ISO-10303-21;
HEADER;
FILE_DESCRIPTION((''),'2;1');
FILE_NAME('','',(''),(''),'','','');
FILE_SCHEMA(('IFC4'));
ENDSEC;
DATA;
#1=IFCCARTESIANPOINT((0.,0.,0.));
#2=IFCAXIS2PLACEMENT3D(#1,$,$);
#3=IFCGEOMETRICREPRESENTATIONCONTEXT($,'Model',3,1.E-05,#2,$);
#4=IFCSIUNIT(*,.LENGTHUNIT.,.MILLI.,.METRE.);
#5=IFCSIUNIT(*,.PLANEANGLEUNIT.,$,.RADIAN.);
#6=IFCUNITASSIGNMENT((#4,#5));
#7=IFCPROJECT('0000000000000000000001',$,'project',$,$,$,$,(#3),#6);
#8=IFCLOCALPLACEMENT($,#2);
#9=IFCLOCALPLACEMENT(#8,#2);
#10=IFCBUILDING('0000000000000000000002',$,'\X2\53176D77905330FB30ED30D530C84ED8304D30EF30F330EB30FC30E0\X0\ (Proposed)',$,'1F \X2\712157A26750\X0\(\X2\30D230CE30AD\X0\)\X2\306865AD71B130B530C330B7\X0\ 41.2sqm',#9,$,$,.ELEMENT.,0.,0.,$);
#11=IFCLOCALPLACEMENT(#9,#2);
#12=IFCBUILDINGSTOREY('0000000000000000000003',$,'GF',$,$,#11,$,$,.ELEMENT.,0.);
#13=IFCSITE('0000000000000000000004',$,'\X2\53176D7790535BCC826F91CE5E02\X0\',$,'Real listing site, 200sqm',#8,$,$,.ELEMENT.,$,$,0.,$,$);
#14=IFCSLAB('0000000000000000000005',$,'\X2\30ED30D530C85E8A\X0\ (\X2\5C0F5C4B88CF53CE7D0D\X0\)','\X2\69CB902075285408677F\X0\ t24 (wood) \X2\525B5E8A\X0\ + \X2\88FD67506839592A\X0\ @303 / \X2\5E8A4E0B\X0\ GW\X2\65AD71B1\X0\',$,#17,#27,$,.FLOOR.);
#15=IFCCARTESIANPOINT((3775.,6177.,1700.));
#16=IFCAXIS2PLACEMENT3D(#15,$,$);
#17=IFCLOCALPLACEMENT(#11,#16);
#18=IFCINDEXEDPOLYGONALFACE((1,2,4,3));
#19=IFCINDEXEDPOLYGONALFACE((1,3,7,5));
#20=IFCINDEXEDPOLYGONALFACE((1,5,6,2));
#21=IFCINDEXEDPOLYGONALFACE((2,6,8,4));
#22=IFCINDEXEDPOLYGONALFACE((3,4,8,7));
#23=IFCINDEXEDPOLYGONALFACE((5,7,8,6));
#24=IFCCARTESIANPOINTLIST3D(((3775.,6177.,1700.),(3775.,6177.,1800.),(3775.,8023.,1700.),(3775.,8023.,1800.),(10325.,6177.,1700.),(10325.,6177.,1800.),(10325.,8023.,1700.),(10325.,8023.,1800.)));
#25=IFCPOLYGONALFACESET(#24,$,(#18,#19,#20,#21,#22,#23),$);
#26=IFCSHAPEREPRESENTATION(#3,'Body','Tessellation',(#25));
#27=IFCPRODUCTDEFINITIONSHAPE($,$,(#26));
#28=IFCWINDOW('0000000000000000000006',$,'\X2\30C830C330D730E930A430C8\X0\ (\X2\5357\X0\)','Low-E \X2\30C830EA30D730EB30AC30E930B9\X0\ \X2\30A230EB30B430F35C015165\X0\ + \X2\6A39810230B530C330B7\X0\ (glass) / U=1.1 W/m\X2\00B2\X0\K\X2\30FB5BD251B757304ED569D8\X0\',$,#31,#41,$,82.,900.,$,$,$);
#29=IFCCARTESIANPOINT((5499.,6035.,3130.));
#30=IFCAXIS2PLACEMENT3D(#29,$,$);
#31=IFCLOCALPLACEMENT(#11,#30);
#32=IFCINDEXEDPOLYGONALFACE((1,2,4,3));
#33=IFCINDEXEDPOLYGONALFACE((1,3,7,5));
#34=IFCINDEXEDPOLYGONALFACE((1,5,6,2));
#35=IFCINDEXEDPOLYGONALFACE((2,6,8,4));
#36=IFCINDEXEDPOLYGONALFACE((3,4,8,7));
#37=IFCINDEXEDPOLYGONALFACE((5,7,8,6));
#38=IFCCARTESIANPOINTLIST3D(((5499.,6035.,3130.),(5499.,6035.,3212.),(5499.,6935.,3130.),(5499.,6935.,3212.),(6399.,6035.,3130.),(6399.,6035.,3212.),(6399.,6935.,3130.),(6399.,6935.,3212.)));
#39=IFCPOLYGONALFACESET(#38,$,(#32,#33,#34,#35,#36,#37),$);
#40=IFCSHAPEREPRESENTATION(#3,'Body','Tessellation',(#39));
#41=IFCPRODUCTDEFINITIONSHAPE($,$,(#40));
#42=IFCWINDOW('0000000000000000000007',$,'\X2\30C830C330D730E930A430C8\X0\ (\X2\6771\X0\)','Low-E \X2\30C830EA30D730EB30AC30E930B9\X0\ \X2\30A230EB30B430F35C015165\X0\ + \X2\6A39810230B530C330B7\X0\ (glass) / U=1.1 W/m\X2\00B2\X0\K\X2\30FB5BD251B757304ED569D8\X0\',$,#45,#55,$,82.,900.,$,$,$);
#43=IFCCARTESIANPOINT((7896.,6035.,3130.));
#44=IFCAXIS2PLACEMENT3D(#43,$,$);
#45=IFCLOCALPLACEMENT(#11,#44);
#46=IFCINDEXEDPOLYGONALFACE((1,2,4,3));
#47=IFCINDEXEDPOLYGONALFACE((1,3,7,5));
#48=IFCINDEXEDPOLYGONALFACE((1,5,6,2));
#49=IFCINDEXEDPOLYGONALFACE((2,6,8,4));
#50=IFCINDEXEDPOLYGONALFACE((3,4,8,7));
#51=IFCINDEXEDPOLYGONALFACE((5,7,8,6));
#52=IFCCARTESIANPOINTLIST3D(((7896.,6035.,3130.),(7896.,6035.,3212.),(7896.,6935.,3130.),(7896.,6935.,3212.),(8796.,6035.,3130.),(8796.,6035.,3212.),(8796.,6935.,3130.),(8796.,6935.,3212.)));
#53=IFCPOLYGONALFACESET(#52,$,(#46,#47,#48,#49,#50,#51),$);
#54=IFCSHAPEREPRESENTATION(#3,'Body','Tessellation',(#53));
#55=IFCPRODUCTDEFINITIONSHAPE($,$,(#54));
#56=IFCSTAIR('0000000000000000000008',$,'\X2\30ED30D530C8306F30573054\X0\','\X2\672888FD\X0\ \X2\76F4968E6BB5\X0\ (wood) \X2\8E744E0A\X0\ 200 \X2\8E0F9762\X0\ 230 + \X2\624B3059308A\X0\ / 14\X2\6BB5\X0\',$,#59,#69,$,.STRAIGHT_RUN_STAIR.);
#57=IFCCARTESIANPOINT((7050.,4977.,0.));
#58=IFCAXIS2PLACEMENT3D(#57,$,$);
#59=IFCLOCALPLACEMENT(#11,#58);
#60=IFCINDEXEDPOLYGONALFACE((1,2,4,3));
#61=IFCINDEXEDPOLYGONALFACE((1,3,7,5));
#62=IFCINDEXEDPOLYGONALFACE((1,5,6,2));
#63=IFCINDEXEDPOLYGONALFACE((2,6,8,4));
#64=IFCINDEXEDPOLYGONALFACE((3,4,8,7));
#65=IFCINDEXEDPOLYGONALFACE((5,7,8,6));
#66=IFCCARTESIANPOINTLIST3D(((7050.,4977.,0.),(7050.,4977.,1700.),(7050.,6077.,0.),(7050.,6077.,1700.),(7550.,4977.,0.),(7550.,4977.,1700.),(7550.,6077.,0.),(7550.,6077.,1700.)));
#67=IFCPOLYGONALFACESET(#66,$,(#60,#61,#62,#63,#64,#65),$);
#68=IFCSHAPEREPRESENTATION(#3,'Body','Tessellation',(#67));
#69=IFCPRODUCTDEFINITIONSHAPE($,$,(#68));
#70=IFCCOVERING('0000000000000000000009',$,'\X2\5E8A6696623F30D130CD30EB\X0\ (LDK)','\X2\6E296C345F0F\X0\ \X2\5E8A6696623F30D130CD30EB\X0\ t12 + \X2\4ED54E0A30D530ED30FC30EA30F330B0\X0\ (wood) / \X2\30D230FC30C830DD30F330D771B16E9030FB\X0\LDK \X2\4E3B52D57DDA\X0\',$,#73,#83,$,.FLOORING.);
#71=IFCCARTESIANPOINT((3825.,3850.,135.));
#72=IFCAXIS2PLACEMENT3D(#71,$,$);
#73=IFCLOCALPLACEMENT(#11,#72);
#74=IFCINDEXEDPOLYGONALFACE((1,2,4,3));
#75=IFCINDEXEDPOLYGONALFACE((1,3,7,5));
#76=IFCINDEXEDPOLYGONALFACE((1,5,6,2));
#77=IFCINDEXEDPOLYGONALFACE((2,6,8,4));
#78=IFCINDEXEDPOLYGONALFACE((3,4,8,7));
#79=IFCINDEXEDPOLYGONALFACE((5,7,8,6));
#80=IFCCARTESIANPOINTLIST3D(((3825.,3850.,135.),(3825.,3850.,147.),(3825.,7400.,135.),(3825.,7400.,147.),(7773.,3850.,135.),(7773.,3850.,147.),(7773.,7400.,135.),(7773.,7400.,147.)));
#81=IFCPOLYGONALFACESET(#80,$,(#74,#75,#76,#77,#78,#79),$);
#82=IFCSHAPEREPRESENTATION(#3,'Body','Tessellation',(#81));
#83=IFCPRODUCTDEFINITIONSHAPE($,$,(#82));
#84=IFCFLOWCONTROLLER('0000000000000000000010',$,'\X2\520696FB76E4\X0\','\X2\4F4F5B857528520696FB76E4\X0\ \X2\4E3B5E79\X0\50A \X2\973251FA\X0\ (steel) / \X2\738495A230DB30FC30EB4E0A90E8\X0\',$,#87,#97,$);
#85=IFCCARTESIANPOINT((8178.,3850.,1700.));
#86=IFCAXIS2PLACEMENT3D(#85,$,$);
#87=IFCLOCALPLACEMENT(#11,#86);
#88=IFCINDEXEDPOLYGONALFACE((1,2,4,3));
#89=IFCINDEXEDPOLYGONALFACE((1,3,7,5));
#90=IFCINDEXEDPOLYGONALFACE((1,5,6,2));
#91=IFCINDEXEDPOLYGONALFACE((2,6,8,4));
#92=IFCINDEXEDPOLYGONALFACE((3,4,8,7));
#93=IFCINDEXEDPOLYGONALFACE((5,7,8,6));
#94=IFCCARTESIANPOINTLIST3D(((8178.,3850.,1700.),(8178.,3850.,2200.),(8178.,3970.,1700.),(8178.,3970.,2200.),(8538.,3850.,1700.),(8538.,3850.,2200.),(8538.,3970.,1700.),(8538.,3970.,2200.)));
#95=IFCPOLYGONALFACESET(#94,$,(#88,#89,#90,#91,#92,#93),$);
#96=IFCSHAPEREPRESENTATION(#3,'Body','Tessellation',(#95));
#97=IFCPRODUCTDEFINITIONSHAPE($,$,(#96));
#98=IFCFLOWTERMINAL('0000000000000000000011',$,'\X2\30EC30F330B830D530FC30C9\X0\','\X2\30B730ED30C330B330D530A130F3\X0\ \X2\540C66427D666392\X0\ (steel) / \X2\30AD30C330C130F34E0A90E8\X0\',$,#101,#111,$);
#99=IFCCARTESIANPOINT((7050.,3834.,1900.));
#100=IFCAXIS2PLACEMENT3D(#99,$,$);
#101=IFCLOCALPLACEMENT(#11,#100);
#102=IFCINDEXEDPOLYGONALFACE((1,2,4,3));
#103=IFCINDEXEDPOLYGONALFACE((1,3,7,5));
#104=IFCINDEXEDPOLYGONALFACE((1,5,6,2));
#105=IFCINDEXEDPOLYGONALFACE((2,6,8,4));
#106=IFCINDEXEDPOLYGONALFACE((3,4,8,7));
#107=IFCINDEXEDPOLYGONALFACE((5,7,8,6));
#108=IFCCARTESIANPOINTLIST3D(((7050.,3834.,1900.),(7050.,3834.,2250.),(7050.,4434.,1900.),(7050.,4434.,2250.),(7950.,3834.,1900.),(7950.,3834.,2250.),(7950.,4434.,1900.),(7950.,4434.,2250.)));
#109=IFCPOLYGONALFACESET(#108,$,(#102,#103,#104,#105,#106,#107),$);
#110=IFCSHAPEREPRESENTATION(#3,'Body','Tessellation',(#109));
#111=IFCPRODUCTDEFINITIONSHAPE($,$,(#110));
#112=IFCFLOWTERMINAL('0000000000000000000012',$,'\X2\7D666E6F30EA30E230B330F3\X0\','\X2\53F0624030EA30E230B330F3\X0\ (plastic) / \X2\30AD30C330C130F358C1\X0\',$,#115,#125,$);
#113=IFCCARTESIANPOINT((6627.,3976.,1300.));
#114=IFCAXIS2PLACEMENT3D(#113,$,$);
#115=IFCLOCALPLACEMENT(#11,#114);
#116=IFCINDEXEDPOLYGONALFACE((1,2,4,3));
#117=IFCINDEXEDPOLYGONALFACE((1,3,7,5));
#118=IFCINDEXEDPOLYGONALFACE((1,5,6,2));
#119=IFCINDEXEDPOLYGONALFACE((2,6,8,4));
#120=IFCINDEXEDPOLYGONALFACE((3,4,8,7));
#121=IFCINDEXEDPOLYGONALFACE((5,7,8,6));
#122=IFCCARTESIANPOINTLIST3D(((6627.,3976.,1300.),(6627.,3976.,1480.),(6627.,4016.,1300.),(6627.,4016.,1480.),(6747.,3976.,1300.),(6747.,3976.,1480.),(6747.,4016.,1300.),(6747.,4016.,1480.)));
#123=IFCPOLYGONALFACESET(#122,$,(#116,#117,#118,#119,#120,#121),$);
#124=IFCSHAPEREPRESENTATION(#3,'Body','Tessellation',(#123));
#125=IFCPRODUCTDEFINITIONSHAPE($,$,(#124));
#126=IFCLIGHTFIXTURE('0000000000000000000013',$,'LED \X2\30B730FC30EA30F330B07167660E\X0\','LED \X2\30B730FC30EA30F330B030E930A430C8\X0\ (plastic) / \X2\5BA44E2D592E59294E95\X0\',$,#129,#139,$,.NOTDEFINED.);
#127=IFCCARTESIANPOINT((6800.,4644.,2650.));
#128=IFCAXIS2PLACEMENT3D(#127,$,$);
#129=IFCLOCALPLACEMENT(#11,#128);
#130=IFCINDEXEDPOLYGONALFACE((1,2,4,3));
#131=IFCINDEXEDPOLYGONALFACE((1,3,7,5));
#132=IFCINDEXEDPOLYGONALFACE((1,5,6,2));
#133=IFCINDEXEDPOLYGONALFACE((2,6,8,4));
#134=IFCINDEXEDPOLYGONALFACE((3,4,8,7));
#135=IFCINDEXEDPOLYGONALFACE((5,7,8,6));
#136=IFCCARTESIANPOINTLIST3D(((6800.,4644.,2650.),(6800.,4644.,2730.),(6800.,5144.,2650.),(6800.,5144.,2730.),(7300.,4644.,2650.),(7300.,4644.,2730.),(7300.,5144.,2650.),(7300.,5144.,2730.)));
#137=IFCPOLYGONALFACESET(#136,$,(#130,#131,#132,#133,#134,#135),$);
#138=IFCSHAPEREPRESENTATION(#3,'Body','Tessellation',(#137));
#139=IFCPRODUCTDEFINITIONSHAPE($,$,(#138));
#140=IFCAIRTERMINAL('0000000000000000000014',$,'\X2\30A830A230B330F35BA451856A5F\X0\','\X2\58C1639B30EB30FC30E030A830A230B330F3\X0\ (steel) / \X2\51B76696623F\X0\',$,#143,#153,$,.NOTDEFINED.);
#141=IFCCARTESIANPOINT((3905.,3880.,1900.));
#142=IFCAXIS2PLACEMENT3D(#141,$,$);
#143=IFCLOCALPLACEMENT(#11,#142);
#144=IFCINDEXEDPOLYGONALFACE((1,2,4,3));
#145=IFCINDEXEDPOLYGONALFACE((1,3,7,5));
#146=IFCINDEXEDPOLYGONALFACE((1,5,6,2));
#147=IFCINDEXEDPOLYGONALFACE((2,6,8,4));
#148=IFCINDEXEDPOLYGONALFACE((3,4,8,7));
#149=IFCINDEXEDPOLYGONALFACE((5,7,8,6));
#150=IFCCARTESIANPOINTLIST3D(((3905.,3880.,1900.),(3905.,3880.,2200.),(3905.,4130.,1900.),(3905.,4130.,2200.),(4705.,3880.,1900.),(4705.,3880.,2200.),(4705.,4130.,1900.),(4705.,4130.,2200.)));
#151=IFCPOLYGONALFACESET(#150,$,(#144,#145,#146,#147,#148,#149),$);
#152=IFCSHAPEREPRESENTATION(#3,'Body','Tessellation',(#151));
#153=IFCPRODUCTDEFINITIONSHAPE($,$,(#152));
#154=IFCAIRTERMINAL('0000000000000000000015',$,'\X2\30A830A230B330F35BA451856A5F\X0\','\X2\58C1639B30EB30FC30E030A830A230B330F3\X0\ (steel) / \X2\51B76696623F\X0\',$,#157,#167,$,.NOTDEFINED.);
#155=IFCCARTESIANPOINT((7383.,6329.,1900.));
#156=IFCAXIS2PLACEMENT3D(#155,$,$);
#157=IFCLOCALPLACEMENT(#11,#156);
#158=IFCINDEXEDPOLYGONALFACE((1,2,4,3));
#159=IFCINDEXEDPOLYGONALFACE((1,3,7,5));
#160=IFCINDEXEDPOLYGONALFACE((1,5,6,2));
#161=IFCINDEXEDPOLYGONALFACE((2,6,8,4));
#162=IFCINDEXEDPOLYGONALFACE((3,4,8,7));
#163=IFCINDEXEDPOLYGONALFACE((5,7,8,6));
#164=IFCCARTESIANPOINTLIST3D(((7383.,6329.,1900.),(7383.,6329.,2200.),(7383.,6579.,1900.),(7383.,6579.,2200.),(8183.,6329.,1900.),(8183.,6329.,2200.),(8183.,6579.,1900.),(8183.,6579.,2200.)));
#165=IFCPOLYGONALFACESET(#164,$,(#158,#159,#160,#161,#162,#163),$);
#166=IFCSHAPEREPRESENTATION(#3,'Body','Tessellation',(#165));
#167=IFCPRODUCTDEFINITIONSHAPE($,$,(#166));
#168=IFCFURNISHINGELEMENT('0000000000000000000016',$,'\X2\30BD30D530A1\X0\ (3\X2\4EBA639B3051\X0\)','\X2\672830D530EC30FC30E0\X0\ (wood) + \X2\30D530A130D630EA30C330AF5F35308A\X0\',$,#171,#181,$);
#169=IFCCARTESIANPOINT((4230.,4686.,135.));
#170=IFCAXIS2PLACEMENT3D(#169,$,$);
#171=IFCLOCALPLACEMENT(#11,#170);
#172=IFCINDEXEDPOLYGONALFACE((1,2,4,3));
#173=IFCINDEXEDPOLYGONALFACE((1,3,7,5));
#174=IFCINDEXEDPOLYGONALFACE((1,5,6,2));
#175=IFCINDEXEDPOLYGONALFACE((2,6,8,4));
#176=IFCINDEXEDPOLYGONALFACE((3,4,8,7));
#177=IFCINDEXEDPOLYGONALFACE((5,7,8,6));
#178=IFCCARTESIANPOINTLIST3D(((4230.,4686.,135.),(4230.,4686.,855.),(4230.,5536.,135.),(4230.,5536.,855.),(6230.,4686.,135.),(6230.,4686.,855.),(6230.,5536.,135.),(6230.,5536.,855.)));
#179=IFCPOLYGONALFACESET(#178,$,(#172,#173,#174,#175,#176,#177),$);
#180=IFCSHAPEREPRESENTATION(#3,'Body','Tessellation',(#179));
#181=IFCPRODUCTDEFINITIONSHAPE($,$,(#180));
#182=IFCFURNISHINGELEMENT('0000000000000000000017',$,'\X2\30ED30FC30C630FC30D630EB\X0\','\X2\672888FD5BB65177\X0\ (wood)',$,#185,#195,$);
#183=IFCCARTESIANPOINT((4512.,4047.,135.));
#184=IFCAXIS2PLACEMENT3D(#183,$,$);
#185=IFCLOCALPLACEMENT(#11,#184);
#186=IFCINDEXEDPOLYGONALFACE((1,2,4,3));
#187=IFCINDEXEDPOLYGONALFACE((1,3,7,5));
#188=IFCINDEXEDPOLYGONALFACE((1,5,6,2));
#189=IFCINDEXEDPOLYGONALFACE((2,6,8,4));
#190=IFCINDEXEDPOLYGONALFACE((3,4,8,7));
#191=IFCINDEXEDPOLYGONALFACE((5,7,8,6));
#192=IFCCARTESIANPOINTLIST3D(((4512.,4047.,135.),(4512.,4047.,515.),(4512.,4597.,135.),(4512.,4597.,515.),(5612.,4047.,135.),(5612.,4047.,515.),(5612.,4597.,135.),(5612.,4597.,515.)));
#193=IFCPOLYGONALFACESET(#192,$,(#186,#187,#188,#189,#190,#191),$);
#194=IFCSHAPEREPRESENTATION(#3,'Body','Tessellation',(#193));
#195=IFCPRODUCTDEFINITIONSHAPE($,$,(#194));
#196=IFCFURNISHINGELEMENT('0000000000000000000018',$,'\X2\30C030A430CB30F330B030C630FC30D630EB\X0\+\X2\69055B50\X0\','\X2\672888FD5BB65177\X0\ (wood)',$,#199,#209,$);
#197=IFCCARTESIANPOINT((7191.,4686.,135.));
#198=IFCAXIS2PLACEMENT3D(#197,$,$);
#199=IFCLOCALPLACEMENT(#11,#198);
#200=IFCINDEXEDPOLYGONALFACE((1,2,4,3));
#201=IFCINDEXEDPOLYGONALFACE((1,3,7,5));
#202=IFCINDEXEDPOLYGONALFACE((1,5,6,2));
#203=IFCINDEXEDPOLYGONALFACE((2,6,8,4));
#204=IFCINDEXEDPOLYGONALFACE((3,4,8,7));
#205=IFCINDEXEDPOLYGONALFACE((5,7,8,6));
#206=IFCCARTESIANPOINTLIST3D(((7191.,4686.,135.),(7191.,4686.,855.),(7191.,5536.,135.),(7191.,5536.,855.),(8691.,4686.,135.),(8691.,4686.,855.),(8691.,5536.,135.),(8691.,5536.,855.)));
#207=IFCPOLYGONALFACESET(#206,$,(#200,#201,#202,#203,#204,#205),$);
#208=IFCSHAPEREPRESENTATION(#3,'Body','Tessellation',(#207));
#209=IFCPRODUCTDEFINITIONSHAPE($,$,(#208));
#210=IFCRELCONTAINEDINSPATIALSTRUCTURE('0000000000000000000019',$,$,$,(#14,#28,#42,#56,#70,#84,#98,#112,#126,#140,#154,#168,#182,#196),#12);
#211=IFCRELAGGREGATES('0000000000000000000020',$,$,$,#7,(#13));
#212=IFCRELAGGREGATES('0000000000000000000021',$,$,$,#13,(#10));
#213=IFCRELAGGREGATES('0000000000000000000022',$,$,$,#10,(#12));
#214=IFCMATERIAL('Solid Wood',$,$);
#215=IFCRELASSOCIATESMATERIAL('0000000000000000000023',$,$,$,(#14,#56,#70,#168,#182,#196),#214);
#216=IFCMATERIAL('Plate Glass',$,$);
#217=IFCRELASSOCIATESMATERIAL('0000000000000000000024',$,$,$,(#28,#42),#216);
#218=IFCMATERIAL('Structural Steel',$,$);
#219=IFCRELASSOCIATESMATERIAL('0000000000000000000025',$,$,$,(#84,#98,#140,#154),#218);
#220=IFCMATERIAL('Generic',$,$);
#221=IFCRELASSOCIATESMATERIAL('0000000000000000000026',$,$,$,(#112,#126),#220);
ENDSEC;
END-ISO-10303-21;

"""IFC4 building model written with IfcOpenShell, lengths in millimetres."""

from ifc_helpers import new_model, si_unit, frame, frame_2d, origin, place, context, project, spatial, rectangle, extrude, material, element, save


model = new_model("IFC4")

# Units and contexts
model_context = context("Model", 3, precision=1e-05, world=origin())
ifc_project = project(units=[si_unit("LENGTHUNIT", "METRE", prefix="MILLI"), si_unit("PLANEANGLEUNIT", "RADIAN")], contexts=[model_context])

# Site, building, storey
site_placement = place(None, origin())
site = spatial("IfcSite", under=ifc_project, at=site_placement, Name="北海道富良野市", ObjectType="Real listing site, 200sqm", CompositionType="ELEMENT", RefElevation=0.0)
building_placement = place(site_placement, origin())
building = spatial("IfcBuilding", under=site, at=building_placement, Name="北海道・ロフト付きワンルーム (Proposed)", ObjectType="1F 無垢材(ヒノキ)と断熱サッシ 41.2sqm", CompositionType="ELEMENT", ElevationOfRefHeight=0.0, ElevationOfTerrain=0.0)
storey_placement = place(building_placement, origin())
storey = spatial("IfcBuildingStorey", under=building, at=storey_placement, Name="GF", CompositionType="ELEMENT", Elevation=0.0)

# Shared definitions
ifc_material_1 = material(Name="Solid Wood")

# Slab
slab_placement = place(storey_placement, frame((3775.0, 6177.0, 1700.0)))
element("IfcSlab", 1, at=slab_placement, inside=storey, material=ifc_material_1, Name="ロフト床 (小屋裏収納)", Description="構造用合板 t24 (wood) 剛床 + 製材根太 @303 / 床下 GW断熱", PredefinedType="FLOOR", context=model_context, shape_type="SweptSolid", body=[
    extrude(rectangle(XDim=6550.0, YDim=1846.0, at=frame_2d((3275.0, 923.0))), frame((3775.0, 6177.0, 1700.0)), (0.0, 0.0, 1.0), 100.0),
])

# Windows
ifc_material_2 = material(Name="Plate Glass")
window_1_placement = place(storey_placement, frame((5499.0, 6035.0, 3130.0)))
element("IfcWindow", 2, at=window_1_placement, inside=storey, material=ifc_material_2, Name="トップライト (南)", Description="Low-E トリプルガラス アルゴン封入 + 樹脂サッシ (glass) / U=1.1 W/m²K・寒冷地仕様", OverallHeight=82.0, OverallWidth=900.0, context=model_context, shape_type="SweptSolid", body=[
    extrude(rectangle(XDim=900.0, YDim=900.0, at=frame_2d((450.0, 450.0))), frame((5499.0, 6035.0, 3130.0)), (0.0, 0.0, 1.0), 82.0),
])
window_2_placement = place(storey_placement, frame((7896.0, 6035.0, 3130.0)))
element("IfcWindow", 3, at=window_2_placement, inside=storey, material=ifc_material_2, Name="トップライト (東)", Description="Low-E トリプルガラス アルゴン封入 + 樹脂サッシ (glass) / U=1.1 W/m²K・寒冷地仕様", OverallHeight=82.0, OverallWidth=900.0, context=model_context, shape_type="SweptSolid", body=[
    extrude(rectangle(XDim=900.0, YDim=900.0, at=frame_2d((450.0, 450.0))), frame((7896.0, 6035.0, 3130.0)), (0.0, 0.0, 1.0), 82.0),
])

# Stair
stair_placement = place(storey_placement, frame((7050.0, 4977.0, 0.0)))
element("IfcStair", 4, at=stair_placement, inside=storey, material=ifc_material_1, Name="ロフトはしご", Description="木製 直階段 (wood) 蹴上 200 踏面 230 + 手すり / 14段", PredefinedType="STRAIGHT_RUN_STAIR", context=model_context, shape_type="SweptSolid", body=[
    extrude(rectangle(XDim=500.0, YDim=1100.0, at=frame_2d((250.0, 550.0))), frame((7050.0, 4977.0, 0.0)), (0.0, 0.0, 1.0), 1700.0),
])

# Covering
covering_placement = place(storey_placement, frame((3825.0, 3850.0, 135.0)))
element("IfcCovering", 5, at=covering_placement, inside=storey, material=ifc_material_1, Name="床暖房パネル (LDK)", Description="温水式 床暖房パネル t12 + 仕上フローリング (wood) / ヒートポンプ熱源・LDK 主動線", PredefinedType="FLOORING", context=model_context, shape_type="SweptSolid", body=[
    extrude(rectangle(XDim=3948.0, YDim=3550.0, at=frame_2d((1974.0, 1775.0))), frame((3825.0, 3850.0, 135.0)), (0.0, 0.0, 1.0), 12.0),
])

# Flow controller
ifc_material_3 = material(Name="Structural Steel")
flow_controller_placement = place(storey_placement, frame((8178.0, 3850.0, 1700.0)))
element("IfcFlowController", 6, at=flow_controller_placement, inside=storey, material=ifc_material_3, Name="分電盤", Description="住宅用分電盤 主幹50A 露出 (steel) / 玄関ホール上部", context=model_context, shape_type="SweptSolid", body=[
    extrude(rectangle(XDim=360.0, YDim=120.0, at=frame_2d((180.0, 60.0))), frame((8178.0, 3850.0, 1700.0)), (0.0, 0.0, 1.0), 500.0),
])

# Flow terminals
flow_terminal_1_placement = place(storey_placement, frame((7050.0, 3834.0, 1900.0)))
element("IfcFlowTerminal", 7, at=flow_terminal_1_placement, inside=storey, material=ifc_material_3, Name="レンジフード", Description="シロッコファン 同時給排 (steel) / キッチン上部", context=model_context, shape_type="SweptSolid", body=[
    extrude(rectangle(XDim=900.0, YDim=600.0, at=frame_2d((450.0, 300.0))), frame((7050.0, 3834.0, 1900.0)), (0.0, 0.0, 1.0), 350.0),
])
ifc_material_4 = material(Name="Generic")
flow_terminal_2_placement = place(storey_placement, frame((6627.0, 3976.0, 1300.0)))
element("IfcFlowTerminal", 8, at=flow_terminal_2_placement, inside=storey, material=ifc_material_4, Name="給湯リモコン", Description="台所リモコン (plastic) / キッチン壁", context=model_context, shape_type="SweptSolid", body=[
    extrude(rectangle(XDim=120.0, YDim=40.0, at=frame_2d((60.0, 20.0))), frame((6627.0, 3976.0, 1300.0)), (0.0, 0.0, 1.0), 180.0),
])

# Light fixture
light_fixture_placement = place(storey_placement, frame((6800.0, 4644.0, 2650.0)))
element("IfcLightFixture", 9, at=light_fixture_placement, inside=storey, material=ifc_material_4, Name="LED シーリング照明", Description="LED シーリングライト (plastic) / 室中央天井", PredefinedType="NOTDEFINED", context=model_context, shape_type="SweptSolid", body=[
    extrude(rectangle(XDim=500.0, YDim=500.0, at=frame_2d((250.0, 250.0))), frame((6800.0, 4644.0, 2650.0)), (0.0, 0.0, 1.0), 80.0),
])

# Air terminals
air_terminal_1_placement = place(storey_placement, frame((3905.0, 3880.0, 1900.0)))
element("IfcAirTerminal", 10, at=air_terminal_1_placement, inside=storey, material=ifc_material_3, Name="エアコン室内機", Description="壁掛ルームエアコン (steel) / 冷暖房", PredefinedType="NOTDEFINED", context=model_context, shape_type="SweptSolid", body=[
    extrude(rectangle(XDim=800.0, YDim=250.0, at=frame_2d((400.0, 125.0))), frame((3905.0, 3880.0, 1900.0)), (0.0, 0.0, 1.0), 300.0),
])
air_terminal_2_placement = place(storey_placement, frame((7383.0, 6329.0, 1900.0)))
element("IfcAirTerminal", 11, at=air_terminal_2_placement, inside=storey, material=ifc_material_3, Name="エアコン室内機", Description="壁掛ルームエアコン (steel) / 冷暖房", PredefinedType="NOTDEFINED", context=model_context, shape_type="SweptSolid", body=[
    extrude(rectangle(XDim=800.0, YDim=250.0, at=frame_2d((400.0, 125.0))), frame((7383.0, 6329.0, 1900.0)), (0.0, 0.0, 1.0), 300.0),
])

# Furnishing elements
furnishing_1_placement = place(storey_placement, frame((4230.0, 4686.0, 135.0)))
element("IfcFurnishingElement", 12, at=furnishing_1_placement, inside=storey, material=ifc_material_1, Name="ソファ (3人掛け)", Description="木フレーム (wood) + ファブリック張り", context=model_context, shape_type="SweptSolid", body=[
    extrude(rectangle(XDim=2000.0, YDim=850.0, at=frame_2d((1000.0, 425.0))), frame((4230.0, 4686.0, 135.0)), (0.0, 0.0, 1.0), 720.0),
])
furnishing_2_placement = place(storey_placement, frame((4512.0, 4047.0, 135.0)))
element("IfcFurnishingElement", 13, at=furnishing_2_placement, inside=storey, material=ifc_material_1, Name="ローテーブル", Description="木製家具 (wood)", context=model_context, shape_type="SweptSolid", body=[
    extrude(rectangle(XDim=1100.0, YDim=550.0, at=frame_2d((550.0, 275.0))), frame((4512.0, 4047.0, 135.0)), (0.0, 0.0, 1.0), 380.0),
])
furnishing_3_placement = place(storey_placement, frame((7191.0, 4686.0, 135.0)))
element("IfcFurnishingElement", 14, at=furnishing_3_placement, inside=storey, material=ifc_material_1, Name="ダイニングテーブル+椅子", Description="木製家具 (wood)", context=model_context, shape_type="SweptSolid", body=[
    extrude(rectangle(XDim=1500.0, YDim=850.0, at=frame_2d((750.0, 425.0))), frame((7191.0, 4686.0, 135.0)), (0.0, 0.0, 1.0), 720.0),
])

save(model, "model.ifc")
